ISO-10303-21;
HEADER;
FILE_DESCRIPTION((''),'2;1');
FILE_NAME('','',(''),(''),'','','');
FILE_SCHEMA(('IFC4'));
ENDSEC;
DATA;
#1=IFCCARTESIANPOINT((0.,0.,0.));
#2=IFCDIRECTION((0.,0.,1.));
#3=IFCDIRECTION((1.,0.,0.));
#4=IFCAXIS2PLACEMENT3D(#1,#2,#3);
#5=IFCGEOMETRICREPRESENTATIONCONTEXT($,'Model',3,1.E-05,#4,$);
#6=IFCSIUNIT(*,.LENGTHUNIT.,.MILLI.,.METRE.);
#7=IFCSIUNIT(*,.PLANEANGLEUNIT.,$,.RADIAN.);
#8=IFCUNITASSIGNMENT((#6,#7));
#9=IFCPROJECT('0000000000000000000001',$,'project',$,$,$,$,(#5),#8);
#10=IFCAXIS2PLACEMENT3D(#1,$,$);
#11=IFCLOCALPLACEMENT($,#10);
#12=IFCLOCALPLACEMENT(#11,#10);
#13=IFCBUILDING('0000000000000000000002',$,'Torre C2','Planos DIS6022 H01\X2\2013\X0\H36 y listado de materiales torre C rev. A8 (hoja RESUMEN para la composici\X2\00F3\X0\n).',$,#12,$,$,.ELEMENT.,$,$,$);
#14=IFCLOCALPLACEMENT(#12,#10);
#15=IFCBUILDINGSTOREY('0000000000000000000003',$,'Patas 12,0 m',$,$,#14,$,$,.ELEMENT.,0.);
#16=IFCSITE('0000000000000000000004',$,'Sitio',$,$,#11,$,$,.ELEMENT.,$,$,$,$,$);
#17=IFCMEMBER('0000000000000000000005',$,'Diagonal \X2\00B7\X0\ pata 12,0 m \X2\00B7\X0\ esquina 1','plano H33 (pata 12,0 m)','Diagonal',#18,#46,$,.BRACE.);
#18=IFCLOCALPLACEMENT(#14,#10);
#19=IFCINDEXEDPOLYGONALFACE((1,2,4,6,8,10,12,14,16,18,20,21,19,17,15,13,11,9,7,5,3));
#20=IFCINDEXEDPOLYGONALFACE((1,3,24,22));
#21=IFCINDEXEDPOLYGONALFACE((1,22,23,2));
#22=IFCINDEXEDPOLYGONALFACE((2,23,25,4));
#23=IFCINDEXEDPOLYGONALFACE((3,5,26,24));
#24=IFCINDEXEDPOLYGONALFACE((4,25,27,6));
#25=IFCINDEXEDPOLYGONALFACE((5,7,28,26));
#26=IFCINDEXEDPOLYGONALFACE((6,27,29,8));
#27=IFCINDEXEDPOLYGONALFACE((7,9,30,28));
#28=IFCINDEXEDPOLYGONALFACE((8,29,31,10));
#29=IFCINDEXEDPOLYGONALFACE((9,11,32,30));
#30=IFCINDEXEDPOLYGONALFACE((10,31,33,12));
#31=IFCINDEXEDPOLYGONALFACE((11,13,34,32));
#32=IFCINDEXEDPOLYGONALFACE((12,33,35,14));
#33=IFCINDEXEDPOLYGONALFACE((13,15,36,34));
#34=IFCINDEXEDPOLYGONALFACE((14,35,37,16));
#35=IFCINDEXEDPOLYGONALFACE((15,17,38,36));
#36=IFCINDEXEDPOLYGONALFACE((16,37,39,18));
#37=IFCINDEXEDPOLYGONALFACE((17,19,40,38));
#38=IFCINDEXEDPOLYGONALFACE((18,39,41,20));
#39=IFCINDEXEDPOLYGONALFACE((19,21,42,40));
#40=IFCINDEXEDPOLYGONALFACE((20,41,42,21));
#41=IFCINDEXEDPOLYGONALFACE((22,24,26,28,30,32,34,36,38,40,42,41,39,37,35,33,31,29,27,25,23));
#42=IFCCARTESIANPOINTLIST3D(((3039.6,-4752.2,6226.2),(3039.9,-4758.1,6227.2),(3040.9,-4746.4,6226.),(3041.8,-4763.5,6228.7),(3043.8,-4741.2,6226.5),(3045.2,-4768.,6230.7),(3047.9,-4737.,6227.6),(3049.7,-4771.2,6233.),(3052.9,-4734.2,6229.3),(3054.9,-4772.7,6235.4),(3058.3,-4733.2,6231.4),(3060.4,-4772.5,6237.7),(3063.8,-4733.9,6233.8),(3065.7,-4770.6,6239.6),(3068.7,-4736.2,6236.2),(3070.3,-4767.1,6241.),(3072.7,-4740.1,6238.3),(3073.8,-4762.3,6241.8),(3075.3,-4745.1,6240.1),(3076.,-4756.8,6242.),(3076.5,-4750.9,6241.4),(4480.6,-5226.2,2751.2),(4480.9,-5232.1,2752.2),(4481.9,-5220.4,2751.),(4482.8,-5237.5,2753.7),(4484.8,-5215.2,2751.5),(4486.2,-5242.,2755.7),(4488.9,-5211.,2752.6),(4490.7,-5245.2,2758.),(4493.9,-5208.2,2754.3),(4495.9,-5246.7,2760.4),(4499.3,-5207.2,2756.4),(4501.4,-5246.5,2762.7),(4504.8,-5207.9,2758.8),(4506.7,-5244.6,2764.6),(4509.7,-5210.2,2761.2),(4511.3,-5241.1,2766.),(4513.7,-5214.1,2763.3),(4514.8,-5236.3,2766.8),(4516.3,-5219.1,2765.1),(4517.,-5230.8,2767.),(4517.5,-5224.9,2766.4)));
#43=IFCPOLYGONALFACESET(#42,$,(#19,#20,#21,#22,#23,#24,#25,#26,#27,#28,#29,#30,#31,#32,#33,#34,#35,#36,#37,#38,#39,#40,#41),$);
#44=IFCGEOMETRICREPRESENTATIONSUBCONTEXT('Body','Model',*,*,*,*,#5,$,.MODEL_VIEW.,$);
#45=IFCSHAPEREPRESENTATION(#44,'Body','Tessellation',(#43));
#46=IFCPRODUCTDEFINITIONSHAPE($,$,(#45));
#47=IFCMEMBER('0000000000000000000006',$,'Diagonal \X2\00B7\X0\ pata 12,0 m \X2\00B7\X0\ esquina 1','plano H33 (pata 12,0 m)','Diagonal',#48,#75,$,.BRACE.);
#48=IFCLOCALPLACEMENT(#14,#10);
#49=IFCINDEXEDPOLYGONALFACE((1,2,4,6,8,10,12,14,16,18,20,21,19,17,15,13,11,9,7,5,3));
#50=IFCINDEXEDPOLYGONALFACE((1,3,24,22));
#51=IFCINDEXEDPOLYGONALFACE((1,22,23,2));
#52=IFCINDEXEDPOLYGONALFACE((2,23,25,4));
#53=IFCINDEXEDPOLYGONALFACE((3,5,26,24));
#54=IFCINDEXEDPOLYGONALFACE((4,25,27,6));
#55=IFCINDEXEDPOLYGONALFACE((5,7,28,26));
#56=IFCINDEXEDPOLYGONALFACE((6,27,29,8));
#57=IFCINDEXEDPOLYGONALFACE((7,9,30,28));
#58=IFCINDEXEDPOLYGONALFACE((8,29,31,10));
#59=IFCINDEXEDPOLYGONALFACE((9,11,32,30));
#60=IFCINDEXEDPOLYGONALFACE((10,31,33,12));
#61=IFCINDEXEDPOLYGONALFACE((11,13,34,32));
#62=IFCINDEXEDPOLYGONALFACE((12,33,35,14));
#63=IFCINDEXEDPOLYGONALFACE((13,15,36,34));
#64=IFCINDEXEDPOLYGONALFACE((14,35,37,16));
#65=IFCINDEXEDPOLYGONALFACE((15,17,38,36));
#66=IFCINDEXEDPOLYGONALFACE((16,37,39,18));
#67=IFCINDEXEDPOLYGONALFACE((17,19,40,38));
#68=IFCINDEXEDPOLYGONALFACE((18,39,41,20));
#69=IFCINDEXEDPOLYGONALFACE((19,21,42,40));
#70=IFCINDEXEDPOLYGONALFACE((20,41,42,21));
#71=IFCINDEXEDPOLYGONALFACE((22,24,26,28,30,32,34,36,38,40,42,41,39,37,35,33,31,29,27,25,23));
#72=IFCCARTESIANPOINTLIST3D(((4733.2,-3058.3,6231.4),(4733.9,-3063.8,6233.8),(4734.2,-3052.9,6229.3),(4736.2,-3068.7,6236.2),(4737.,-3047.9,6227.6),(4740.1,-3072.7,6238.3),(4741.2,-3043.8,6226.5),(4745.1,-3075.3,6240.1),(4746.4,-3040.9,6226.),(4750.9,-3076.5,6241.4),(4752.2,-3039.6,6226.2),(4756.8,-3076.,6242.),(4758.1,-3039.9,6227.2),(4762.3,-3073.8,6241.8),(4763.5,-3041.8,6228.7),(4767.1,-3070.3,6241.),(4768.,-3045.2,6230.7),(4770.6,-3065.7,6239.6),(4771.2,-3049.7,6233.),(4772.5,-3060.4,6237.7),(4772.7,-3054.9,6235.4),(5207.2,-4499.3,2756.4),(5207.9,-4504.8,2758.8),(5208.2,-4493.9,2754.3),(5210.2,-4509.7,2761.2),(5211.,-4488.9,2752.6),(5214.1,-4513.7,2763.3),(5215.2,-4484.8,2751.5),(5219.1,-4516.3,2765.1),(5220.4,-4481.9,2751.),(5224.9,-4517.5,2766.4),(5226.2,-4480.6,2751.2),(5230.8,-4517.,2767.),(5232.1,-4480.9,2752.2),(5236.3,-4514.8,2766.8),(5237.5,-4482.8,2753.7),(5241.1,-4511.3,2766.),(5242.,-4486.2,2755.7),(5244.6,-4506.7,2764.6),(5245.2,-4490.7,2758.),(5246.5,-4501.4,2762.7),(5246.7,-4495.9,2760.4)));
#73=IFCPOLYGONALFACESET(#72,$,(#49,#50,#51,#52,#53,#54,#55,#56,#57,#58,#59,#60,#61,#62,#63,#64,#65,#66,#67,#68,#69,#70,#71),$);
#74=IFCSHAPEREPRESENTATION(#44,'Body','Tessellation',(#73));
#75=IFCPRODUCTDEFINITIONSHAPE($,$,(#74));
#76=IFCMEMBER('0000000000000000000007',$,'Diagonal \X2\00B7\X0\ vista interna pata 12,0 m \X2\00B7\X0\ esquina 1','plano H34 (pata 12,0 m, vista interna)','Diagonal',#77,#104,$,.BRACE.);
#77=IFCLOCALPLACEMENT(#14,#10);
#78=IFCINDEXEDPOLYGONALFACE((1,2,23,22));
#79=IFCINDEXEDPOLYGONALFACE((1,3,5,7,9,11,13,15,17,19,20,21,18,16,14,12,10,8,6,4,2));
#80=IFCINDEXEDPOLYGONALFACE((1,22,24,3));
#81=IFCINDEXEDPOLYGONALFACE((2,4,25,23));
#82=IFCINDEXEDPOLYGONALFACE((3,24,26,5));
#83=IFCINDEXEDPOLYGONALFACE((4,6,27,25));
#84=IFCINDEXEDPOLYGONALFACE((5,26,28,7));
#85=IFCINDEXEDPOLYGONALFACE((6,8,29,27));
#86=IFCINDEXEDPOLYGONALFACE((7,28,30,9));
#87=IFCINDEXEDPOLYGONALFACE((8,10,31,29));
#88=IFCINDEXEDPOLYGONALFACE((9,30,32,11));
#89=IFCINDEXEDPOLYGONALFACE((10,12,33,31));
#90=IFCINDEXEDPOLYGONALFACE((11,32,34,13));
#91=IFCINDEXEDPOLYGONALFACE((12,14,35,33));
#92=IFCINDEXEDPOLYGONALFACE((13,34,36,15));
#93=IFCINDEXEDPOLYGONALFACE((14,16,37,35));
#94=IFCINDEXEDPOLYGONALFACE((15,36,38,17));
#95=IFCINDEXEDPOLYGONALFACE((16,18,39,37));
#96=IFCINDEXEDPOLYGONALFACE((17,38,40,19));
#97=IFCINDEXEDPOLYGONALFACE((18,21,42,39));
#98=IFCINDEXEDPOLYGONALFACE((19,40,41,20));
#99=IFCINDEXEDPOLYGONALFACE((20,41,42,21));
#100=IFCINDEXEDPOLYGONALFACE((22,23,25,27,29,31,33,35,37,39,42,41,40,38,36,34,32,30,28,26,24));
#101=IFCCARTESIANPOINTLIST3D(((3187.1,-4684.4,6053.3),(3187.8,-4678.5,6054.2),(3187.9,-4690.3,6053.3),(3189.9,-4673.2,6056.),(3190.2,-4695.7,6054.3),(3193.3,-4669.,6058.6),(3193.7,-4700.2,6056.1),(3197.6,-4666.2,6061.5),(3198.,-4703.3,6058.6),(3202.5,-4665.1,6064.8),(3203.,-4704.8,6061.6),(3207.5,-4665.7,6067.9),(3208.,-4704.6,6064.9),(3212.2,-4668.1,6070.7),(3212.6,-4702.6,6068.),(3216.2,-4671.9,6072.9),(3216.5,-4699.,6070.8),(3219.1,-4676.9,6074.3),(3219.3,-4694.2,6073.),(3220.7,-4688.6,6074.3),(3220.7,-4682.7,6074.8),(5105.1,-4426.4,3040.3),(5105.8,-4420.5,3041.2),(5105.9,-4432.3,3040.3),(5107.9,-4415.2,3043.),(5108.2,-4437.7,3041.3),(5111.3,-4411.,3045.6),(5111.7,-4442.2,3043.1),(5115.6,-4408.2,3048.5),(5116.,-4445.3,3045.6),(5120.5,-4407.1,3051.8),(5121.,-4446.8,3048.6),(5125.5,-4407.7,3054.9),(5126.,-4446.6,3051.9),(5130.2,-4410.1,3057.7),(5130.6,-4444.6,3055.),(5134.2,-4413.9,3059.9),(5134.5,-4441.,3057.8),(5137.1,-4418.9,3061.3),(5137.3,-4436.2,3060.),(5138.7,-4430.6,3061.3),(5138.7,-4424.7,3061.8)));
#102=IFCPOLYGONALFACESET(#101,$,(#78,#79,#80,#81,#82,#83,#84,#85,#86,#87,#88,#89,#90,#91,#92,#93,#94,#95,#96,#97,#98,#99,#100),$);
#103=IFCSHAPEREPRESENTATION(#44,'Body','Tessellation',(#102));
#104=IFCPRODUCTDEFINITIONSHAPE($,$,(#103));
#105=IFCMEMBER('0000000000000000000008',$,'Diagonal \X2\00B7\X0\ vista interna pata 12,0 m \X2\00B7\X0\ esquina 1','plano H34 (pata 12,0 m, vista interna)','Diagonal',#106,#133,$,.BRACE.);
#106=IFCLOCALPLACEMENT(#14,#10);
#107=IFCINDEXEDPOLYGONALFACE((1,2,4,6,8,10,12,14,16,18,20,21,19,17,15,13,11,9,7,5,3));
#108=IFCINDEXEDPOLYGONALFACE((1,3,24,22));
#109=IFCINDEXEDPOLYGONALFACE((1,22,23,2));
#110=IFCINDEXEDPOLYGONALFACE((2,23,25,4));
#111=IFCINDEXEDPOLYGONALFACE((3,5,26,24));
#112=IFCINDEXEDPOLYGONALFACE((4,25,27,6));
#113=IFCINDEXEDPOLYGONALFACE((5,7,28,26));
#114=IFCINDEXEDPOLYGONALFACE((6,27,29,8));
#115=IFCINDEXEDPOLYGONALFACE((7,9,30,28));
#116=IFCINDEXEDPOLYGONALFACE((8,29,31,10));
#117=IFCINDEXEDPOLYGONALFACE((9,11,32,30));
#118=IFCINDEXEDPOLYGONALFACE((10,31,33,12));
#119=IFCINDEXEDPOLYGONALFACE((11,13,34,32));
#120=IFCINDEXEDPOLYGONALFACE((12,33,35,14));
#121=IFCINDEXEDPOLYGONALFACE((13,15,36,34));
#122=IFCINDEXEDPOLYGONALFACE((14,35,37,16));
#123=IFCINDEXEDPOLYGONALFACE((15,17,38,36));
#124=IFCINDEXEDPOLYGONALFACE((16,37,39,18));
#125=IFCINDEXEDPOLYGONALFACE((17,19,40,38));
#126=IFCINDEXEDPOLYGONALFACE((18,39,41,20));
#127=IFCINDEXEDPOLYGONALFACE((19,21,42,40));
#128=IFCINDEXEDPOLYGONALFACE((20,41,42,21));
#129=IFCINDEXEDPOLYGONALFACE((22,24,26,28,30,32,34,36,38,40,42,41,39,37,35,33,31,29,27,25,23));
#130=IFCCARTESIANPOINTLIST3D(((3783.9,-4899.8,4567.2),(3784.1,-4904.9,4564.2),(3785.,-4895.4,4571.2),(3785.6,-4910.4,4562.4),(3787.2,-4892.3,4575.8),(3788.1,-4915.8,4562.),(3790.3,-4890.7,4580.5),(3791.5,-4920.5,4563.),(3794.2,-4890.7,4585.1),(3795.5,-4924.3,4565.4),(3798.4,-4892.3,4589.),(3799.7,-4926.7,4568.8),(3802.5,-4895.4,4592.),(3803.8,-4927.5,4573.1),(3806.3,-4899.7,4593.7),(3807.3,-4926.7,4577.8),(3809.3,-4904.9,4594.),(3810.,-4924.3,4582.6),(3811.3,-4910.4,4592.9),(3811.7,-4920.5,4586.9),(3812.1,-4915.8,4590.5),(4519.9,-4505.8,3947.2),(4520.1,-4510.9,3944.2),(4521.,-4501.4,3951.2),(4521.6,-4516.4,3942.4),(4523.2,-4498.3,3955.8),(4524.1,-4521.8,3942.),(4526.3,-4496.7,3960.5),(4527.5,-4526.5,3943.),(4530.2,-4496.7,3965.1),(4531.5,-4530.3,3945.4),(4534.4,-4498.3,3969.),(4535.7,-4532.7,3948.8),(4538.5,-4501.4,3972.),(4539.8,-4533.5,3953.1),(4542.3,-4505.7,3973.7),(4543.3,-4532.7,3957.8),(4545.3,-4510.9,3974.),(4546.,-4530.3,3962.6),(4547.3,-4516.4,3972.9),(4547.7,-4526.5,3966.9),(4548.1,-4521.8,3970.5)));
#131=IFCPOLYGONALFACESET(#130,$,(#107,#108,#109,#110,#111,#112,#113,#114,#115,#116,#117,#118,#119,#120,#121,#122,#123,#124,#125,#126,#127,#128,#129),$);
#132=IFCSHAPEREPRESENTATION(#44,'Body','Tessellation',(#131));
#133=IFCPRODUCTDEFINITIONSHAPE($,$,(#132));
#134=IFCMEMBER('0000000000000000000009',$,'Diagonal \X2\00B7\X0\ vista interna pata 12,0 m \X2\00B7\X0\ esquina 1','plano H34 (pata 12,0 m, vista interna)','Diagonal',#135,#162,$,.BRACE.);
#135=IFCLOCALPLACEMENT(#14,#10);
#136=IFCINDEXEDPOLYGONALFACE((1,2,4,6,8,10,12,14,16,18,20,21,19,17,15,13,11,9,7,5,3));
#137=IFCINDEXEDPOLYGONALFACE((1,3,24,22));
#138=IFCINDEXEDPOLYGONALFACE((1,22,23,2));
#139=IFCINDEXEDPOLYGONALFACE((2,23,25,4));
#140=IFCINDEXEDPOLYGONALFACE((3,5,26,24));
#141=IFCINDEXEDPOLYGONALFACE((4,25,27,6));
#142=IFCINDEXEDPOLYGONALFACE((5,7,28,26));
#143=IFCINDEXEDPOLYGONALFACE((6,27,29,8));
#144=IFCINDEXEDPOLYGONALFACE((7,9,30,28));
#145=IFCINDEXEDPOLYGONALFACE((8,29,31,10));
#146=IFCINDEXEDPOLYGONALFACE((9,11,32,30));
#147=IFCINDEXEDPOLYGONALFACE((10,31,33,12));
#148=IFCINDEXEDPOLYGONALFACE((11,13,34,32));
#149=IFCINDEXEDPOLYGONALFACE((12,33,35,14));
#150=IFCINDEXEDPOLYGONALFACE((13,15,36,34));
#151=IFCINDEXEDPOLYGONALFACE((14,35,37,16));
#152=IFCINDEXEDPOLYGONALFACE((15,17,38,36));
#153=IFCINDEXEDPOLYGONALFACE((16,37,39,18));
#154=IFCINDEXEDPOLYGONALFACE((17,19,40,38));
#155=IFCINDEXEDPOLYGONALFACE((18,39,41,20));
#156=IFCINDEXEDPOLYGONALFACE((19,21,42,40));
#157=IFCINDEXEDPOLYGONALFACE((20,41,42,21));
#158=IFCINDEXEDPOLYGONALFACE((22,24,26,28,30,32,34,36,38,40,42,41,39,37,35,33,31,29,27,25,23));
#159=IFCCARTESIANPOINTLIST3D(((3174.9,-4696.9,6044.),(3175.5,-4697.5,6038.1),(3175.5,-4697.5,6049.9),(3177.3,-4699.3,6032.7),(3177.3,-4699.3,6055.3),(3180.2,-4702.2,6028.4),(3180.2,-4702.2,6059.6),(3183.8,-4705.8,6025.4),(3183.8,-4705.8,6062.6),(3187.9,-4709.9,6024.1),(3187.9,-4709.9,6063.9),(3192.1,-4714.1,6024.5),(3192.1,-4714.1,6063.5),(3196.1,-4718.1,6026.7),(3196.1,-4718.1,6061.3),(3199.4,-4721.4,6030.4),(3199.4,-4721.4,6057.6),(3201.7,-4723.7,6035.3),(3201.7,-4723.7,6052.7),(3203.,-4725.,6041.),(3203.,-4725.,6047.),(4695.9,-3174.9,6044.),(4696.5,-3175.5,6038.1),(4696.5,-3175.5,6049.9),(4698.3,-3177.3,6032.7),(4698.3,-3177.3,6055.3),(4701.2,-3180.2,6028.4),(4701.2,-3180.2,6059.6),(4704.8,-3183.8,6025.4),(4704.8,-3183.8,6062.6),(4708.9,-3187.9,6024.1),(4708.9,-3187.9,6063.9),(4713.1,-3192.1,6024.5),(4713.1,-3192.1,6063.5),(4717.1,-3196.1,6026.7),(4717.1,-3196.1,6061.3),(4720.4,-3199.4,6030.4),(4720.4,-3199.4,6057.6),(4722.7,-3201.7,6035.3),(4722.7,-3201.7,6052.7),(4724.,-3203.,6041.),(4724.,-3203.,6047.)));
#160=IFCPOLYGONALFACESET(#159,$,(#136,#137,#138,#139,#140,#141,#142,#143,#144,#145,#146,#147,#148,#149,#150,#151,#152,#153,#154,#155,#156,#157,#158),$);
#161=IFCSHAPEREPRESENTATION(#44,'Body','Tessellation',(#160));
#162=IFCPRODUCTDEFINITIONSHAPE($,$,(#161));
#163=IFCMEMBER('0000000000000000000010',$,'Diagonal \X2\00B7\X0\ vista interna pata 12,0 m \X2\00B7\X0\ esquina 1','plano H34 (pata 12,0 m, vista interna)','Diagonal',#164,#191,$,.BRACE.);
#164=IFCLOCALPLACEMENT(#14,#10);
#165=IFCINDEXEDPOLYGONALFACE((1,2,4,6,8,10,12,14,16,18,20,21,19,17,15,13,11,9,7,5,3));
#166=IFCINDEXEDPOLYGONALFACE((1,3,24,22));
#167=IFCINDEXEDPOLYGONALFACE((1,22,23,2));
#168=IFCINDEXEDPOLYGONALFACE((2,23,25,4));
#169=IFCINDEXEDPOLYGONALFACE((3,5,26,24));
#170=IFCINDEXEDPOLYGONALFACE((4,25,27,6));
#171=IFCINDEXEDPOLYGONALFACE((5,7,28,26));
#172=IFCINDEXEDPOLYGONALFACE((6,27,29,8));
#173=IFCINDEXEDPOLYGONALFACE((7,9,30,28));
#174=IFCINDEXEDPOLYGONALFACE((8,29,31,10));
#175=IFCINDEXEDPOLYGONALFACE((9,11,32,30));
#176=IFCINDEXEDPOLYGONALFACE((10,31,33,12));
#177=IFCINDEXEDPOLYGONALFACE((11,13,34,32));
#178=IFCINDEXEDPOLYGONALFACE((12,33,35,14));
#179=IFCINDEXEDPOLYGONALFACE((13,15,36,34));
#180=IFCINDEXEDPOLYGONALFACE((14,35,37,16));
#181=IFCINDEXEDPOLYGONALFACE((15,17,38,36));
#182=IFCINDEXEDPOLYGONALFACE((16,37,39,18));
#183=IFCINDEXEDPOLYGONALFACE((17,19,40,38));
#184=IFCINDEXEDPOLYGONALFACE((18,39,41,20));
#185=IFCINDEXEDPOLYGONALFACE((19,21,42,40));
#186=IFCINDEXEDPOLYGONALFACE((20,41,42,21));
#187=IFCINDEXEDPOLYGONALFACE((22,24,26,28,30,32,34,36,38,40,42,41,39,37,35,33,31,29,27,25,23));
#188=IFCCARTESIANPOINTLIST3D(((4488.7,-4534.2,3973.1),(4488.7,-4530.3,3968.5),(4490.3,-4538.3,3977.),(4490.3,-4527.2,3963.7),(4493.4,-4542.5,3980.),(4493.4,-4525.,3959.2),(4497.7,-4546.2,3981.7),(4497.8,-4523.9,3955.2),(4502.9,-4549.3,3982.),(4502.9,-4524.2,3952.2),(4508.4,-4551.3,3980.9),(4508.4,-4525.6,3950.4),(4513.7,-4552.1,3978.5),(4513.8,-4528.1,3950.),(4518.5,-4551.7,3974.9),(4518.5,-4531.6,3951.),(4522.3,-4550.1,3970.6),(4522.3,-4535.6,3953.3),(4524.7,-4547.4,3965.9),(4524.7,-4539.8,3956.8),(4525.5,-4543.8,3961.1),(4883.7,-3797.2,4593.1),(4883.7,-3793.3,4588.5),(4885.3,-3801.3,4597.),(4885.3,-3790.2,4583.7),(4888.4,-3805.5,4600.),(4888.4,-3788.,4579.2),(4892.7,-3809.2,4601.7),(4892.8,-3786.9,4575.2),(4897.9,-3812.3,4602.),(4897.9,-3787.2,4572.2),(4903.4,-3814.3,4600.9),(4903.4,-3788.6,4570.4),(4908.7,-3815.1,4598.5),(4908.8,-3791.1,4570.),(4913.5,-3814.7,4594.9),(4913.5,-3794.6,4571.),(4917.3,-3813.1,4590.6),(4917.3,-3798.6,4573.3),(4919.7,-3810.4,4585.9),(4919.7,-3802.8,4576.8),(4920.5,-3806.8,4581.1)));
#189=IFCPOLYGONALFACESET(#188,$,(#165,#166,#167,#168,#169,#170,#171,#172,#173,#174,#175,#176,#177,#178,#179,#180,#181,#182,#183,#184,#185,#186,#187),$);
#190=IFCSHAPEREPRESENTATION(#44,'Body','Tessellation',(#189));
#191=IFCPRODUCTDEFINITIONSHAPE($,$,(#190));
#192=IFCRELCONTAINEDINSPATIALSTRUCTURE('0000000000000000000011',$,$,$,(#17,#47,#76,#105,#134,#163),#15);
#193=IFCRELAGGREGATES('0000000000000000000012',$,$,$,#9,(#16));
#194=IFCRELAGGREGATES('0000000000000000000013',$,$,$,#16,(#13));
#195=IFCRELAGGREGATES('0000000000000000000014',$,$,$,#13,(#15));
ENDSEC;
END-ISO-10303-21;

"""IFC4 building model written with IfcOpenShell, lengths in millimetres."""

from ifc_helpers import new_model, si_unit, frame, origin, origin_with_axes, place, context, subcontext, project, spatial, circle, extrude, element, save


model = new_model("IFC4")

# Units and contexts
model_context = context("Model", 3, precision=1e-05, world=origin_with_axes())
body_context = subcontext(model_context, "Body", "Model", "MODEL_VIEW")
ifc_project = project(units=[si_unit("LENGTHUNIT", "METRE", prefix="MILLI"), si_unit("PLANEANGLEUNIT", "RADIAN")], contexts=[model_context])

# Site, building, storey
site_placement = place(None, origin())
site = spatial("IfcSite", under=ifc_project, at=site_placement, Name="Sitio", CompositionType="ELEMENT")
building_placement = place(site_placement, origin())
building = spatial("IfcBuilding", under=site, at=building_placement, Name="Torre C2", Description="Planos DIS6022 H01–H36 y listado de materiales torre C rev. A8 (hoja RESUMEN para la composición).", CompositionType="ELEMENT")
storey_placement = place(building_placement, origin())
storey = spatial("IfcBuildingStorey", under=building, at=storey_placement, Name="Patas 12,0 m", CompositionType="ELEMENT", Elevation=0.0)

# Members
for number, where, z_axis, x_axis, name in (
    (1, (3058.0, -4753.0, 6234.0), (0.380043, -0.125011, -0.916482), (-0.506839, 0.80069, -0.31939), "Diagonal · pata 12,0 m · esquina 1"),
    (2, (4753.0, -3058.0, 6234.0), (0.125011, -0.380043, -0.916482), (-0.80069, 0.506839, -0.31939), "Diagonal · pata 12,0 m · esquina 1"),
):
    element("IfcMember", number, at=place(storey_placement, frame(where, z_axis=z_axis, x_axis=x_axis)), inside=storey, Name=name, Description="plano H33 (pata 12,0 m)", ObjectType="Diagonal", PredefinedType="BRACE", context=body_context, shape_type="SweptSolid", body=[
        extrude(circle(Radius=20.0), None, (0.0, 0.0, 1.0), 3791.7),
    ])
member_1_placement = place(storey_placement, frame((3204.0, -4685.0, 6064.0), z_axis=(0.535607, 0.072047, -0.841388), x_axis=(-0.535581, 0.799312, -0.272493)))
element("IfcMember", 3, at=member_1_placement, inside=storey, Name="Diagonal · vista interna pata 12,0 m · esquina 1", Description="plano H34 (pata 12,0 m, vista interna)", ObjectType="Diagonal", PredefinedType="BRACE", context=body_context, shape_type="SweptSolid", body=[
    extrude(circle(Radius=20.0), None, (0.0, 0.0, 1.0), 3581.0),
])
member_2_placement = place(storey_placement, frame((3798.0, -4909.0, 4578.0), z_axis=(0.70778, 0.378893, -0.596228), x_axis=(-0.540793, 0.833638, -0.11221)))
element("IfcMember", 4, at=member_2_placement, inside=storey, Name="Diagonal · vista interna pata 12,0 m · esquina 1", Description="plano H34 (pata 12,0 m, vista interna)", ObjectType="Diagonal", PredefinedType="BRACE", context=body_context, shape_type="SweptSolid", body=[
    extrude(circle(Radius=20.0), None, (0.0, 0.0, 1.0), 1039.9),
])
member_3_placement = place(storey_placement, frame((3189.0, -4711.0, 6044.0), z_axis=(0.706874, 0.707339, 0.0), x_axis=(-0.707339, 0.706874, 0.0)))
element("IfcMember", 5, at=member_3_placement, inside=storey, Name="Diagonal · vista interna pata 12,0 m · esquina 1", Description="plano H34 (pata 12,0 m, vista interna)", ObjectType="Diagonal", PredefinedType="BRACE", context=body_context, shape_type="SweptSolid", body=[
    extrude(circle(Radius=20.0), None, (0.0, 0.0, 1.0), 2151.7),
])
member_4_placement = place(storey_placement, frame((4507.0, -4538.0, 3966.0), z_axis=(0.379458, 0.708002, 0.595605), x_axis=(-0.833294, 0.541259, -0.112511)))
element("IfcMember", 6, at=member_4_placement, inside=storey, Name="Diagonal · vista interna pata 12,0 m · esquina 1", Description="plano H34 (pata 12,0 m, vista interna)", ObjectType="Diagonal", PredefinedType="BRACE", context=body_context, shape_type="SweptSolid", body=[
    extrude(circle(Radius=20.0), None, (0.0, 0.0, 1.0), 1041.0),
])

save(model, "model.ifc")
